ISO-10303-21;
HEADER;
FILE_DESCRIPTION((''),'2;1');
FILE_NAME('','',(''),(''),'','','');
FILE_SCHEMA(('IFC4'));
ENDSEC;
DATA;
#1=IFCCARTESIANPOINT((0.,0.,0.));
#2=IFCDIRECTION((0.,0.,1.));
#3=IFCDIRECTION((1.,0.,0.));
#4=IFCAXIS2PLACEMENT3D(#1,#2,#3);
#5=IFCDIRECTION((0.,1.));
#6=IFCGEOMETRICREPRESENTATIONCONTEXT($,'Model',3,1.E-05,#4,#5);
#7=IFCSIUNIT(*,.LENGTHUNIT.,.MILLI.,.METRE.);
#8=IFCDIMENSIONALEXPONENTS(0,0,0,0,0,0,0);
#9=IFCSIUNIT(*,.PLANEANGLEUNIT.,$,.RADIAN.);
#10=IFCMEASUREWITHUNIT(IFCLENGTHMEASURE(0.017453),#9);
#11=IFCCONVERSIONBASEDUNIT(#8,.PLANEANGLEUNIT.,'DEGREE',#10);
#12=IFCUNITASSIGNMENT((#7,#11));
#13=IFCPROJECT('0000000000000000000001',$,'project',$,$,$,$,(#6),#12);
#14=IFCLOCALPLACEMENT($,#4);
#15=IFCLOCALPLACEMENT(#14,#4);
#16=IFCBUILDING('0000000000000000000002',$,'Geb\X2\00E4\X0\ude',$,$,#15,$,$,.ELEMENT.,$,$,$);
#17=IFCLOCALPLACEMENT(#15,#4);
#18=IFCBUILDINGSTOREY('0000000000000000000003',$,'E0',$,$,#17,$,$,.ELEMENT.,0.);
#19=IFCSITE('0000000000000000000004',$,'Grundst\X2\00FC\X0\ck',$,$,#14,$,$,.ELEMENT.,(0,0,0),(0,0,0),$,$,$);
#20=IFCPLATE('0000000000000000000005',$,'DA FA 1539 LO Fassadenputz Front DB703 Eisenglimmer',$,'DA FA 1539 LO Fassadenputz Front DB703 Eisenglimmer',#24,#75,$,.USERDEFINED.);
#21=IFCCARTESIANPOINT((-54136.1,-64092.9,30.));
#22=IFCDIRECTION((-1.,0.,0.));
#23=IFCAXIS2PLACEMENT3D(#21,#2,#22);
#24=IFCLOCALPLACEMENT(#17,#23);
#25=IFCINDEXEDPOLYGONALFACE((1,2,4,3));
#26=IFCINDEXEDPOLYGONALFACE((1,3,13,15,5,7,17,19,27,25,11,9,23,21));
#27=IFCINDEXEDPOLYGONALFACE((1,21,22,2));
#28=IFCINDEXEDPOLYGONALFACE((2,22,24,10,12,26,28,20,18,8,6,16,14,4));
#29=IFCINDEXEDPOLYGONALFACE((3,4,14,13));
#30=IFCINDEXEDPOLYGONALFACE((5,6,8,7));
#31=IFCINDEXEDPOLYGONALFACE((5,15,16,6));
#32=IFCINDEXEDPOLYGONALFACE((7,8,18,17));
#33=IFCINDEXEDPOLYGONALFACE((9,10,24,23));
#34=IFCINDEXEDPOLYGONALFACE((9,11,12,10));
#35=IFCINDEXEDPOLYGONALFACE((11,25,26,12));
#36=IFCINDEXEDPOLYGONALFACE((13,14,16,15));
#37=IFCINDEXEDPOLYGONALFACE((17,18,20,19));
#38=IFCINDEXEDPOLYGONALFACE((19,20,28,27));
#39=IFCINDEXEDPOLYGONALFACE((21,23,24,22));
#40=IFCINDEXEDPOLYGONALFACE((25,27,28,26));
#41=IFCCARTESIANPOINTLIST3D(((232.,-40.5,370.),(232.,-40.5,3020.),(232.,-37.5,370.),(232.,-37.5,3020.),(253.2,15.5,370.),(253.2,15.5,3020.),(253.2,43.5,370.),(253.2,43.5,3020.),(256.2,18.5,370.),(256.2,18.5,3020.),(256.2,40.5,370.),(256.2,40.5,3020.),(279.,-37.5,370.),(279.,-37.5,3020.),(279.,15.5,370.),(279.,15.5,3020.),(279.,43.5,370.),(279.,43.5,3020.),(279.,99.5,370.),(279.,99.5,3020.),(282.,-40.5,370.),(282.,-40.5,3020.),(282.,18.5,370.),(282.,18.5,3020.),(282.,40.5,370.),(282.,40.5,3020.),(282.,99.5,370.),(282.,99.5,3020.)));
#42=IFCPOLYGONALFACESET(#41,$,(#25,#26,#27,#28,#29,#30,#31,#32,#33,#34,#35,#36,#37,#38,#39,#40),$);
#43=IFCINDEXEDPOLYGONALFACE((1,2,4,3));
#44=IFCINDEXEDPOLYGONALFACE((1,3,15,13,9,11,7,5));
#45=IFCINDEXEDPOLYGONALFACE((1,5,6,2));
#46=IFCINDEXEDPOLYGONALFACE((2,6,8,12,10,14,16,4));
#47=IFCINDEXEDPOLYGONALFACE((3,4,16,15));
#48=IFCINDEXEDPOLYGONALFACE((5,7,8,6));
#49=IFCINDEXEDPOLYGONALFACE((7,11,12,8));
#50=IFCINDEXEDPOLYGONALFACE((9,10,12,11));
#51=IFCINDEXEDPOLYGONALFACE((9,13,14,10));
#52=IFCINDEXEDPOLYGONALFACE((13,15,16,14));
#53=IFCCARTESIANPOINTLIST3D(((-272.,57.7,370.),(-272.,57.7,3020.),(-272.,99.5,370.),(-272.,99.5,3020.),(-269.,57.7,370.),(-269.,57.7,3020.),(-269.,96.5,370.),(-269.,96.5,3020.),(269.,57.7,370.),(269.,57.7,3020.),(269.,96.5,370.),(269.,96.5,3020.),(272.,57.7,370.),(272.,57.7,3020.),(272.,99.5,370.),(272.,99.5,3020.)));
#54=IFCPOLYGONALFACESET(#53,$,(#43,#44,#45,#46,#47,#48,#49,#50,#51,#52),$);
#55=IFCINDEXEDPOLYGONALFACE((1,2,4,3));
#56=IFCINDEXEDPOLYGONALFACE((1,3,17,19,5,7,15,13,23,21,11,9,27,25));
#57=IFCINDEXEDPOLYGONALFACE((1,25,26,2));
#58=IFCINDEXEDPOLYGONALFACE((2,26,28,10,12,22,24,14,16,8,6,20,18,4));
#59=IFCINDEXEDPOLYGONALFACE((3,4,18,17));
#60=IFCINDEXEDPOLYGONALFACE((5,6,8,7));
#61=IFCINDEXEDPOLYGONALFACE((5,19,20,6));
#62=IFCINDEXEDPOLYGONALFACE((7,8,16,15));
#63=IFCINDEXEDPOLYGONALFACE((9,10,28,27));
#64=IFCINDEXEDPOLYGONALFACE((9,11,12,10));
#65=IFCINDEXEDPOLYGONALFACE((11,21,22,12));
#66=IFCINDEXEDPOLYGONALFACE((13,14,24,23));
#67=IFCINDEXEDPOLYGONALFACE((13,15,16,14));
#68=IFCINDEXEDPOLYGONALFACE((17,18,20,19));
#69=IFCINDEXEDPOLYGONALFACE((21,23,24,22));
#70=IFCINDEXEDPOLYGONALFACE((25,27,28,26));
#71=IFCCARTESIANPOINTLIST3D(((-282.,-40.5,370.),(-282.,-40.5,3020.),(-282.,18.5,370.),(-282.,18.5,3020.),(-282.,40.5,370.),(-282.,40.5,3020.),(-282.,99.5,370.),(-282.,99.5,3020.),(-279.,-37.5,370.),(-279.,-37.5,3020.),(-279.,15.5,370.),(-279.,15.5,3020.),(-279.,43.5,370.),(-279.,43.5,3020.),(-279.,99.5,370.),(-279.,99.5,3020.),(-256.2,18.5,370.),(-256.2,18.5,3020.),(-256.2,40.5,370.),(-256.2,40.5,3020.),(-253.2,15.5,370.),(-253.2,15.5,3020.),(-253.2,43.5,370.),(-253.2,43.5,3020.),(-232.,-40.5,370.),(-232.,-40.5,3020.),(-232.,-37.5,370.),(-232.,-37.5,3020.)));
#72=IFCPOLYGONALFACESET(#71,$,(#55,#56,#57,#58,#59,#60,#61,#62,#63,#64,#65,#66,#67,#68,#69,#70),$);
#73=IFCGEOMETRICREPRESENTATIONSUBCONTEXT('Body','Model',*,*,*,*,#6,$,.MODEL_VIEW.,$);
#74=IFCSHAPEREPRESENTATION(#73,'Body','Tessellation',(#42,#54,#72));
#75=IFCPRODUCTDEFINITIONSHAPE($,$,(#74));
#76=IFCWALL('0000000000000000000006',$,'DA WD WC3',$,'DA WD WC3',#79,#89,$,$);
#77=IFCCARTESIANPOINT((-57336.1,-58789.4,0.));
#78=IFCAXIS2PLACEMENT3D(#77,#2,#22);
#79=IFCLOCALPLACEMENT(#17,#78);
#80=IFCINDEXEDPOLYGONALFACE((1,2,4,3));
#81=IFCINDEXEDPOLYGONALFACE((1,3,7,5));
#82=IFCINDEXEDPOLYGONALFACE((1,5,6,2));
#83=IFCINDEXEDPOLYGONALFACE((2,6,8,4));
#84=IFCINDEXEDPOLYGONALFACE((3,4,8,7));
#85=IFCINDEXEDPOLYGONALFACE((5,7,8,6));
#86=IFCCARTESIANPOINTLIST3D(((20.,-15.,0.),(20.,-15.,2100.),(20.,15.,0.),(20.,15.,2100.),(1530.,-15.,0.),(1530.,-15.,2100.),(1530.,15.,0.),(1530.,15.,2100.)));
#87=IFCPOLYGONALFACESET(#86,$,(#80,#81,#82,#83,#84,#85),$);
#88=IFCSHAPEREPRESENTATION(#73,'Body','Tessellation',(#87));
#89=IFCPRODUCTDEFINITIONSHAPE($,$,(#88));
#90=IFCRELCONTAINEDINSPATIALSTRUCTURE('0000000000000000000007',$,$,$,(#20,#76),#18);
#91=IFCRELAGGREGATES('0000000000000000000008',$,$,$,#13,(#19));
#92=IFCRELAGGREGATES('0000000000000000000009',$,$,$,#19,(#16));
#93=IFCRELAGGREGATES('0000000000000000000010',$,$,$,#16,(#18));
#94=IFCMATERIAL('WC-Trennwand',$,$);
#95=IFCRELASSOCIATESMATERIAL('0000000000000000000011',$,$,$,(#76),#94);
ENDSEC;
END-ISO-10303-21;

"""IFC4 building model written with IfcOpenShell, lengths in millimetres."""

from ifc_helpers import new_model, entity, si_unit, converted_unit, direction, frame, origin_with_axes, place, context, subcontext, project, spatial, line, indexed_curve, outline, extrude, source, transform, mapped, material, element, save


model = new_model("IFC4")

# Units and contexts
model_context = context("Model", 3, precision=1e-05, world=origin_with_axes(), true_north=direction((0.0, 1.0)))
body_context = subcontext(model_context, "Body", "Model", "MODEL_VIEW")
ifc_project = project(units=[si_unit("LENGTHUNIT", "METRE", prefix="MILLI"), converted_unit("PLANEANGLEUNIT", "DEGREE", entity("IfcLengthMeasure", 0.017453), si_unit("PLANEANGLEUNIT", "RADIAN"), dimensions=[0, 0, 0, 0, 0, 0, 0])], contexts=[model_context])

# Site, building, storey
site_placement = place(None, origin_with_axes())
site = spatial("IfcSite", under=ifc_project, at=site_placement, Name="Grundstück", CompositionType="ELEMENT", RefLatitude=(0, 0, 0), RefLongitude=(0, 0, 0))
building_placement = place(site_placement, origin_with_axes())
building = spatial("IfcBuilding", under=site, at=building_placement, Name="Gebäude", CompositionType="ELEMENT")
storey_placement = place(building_placement, origin_with_axes())
storey = spatial("IfcBuildingStorey", under=building, at=storey_placement, Name="E0", CompositionType="ELEMENT", Elevation=0.0)

# Plate
shared_shape_1 = source(origin_with_axes(), body_context, "Body", "SweptSolid", [
    extrude(outline(indexed_curve([(282.0, 99.5), (282.0, 40.5), (256.2, 40.5), (256.2, 18.5), (282.0, 18.5), (282.0, -40.5), (232.0, -40.5), (232.0, -37.5), (279.0, -37.5), (279.0, 15.5), (253.2, 15.5), (253.2, 43.5), (279.0, 43.5), (279.0, 99.5)], segments=[line(1, 2), line(2, 3), line(3, 4), line(4, 5), line(5, 6), line(6, 7), line(7, 8), line(8, 9), line(9, 10), line(10, 11), line(11, 12), line(12, 13), line(13, 14), line(14, 1)])), frame((0.0, 0.0, 370.0), z_axis=(0.0, 0.0, 1.0), x_axis=(1.0, 0.0, 0.0)), (0.0, 0.0, 1.0), 2650.0),
    extrude(outline(indexed_curve([(272.0, 99.5), (272.0, 57.7), (269.0, 57.7), (269.0, 96.5), (-269.0, 96.5), (-269.0, 57.7), (-272.0, 57.7), (-272.0, 99.5)], segments=[line(1, 2), line(2, 3), line(3, 4), line(4, 5), line(5, 6), line(6, 7), line(7, 8), line(8, 1)])), frame((0.0, 0.0, 370.0), z_axis=(0.0, 0.0, 1.0), x_axis=(1.0, 0.0, 0.0)), (0.0, 0.0, 1.0), 2650.0),
    extrude(outline(indexed_curve([(-282.0, 99.5), (-282.0, 40.5), (-256.2, 40.5), (-256.2, 18.5), (-282.0, 18.5), (-282.0, -40.5), (-232.0, -40.5), (-232.0, -37.5), (-279.0, -37.5), (-279.0, 15.5), (-253.2, 15.5), (-253.2, 43.5), (-279.0, 43.5), (-279.0, 99.5)], segments=[line(1, 2), line(2, 3), line(3, 4), line(4, 5), line(5, 6), line(6, 7), line(7, 8), line(8, 9), line(9, 10), line(10, 11), line(11, 12), line(12, 13), line(13, 14), line(14, 1)])), frame((0.0, 0.0, 370.0), z_axis=(0.0, 0.0, 1.0), x_axis=(1.0, 0.0, 0.0)), (0.0, 0.0, 1.0), 2650.0),
])
plate_1_placement = place(storey_placement, frame((-54136.1, -64092.9, 30.0), z_axis=(0.0, 0.0, 1.0), x_axis=(-1.0, 0.0, 0.0)))
element("IfcPlate", 1, at=plate_1_placement, inside=storey, Name="DA FA 1539 LO Fassadenputz Front DB703 Eisenglimmer", ObjectType="DA FA 1539 LO Fassadenputz Front DB703 Eisenglimmer", PredefinedType="USERDEFINED", context=body_context, shape_type="MappedRepresentation", body=[
    mapped(shared_shape_1, transform((0.0, 0.0, 0.0), x_axis=(1.0, 0.0, 0.0), y_axis=(0.0, 1.0, 0.0), z_axis=(0.0, 0.0, 1.0), scale=1.0)),
])

# Wall
ifc_material_1 = material(Name="WC-Trennwand")
wall_1_placement = place(storey_placement, frame((-57336.1, -58789.4, 0.0), z_axis=(0.0, 0.0, 1.0), x_axis=(-1.0, 0.0, 0.0)))
element("IfcWall", 2, at=wall_1_placement, inside=storey, material=ifc_material_1, Name="DA WD WC3", ObjectType="DA WD WC3", context=body_context, shape_type="SweptSolid", body=[
    extrude(outline(indexed_curve([(20.0, -15.0), (20.0, 15.0), (1530.0, 15.0), (1530.0, -15.0)], segments=[line(1, 2), line(2, 3), line(3, 4), line(4, 1)])), origin_with_axes(), (0.0, 0.0, 1.0), 2100.0),
])

save(model, "model.ifc")
